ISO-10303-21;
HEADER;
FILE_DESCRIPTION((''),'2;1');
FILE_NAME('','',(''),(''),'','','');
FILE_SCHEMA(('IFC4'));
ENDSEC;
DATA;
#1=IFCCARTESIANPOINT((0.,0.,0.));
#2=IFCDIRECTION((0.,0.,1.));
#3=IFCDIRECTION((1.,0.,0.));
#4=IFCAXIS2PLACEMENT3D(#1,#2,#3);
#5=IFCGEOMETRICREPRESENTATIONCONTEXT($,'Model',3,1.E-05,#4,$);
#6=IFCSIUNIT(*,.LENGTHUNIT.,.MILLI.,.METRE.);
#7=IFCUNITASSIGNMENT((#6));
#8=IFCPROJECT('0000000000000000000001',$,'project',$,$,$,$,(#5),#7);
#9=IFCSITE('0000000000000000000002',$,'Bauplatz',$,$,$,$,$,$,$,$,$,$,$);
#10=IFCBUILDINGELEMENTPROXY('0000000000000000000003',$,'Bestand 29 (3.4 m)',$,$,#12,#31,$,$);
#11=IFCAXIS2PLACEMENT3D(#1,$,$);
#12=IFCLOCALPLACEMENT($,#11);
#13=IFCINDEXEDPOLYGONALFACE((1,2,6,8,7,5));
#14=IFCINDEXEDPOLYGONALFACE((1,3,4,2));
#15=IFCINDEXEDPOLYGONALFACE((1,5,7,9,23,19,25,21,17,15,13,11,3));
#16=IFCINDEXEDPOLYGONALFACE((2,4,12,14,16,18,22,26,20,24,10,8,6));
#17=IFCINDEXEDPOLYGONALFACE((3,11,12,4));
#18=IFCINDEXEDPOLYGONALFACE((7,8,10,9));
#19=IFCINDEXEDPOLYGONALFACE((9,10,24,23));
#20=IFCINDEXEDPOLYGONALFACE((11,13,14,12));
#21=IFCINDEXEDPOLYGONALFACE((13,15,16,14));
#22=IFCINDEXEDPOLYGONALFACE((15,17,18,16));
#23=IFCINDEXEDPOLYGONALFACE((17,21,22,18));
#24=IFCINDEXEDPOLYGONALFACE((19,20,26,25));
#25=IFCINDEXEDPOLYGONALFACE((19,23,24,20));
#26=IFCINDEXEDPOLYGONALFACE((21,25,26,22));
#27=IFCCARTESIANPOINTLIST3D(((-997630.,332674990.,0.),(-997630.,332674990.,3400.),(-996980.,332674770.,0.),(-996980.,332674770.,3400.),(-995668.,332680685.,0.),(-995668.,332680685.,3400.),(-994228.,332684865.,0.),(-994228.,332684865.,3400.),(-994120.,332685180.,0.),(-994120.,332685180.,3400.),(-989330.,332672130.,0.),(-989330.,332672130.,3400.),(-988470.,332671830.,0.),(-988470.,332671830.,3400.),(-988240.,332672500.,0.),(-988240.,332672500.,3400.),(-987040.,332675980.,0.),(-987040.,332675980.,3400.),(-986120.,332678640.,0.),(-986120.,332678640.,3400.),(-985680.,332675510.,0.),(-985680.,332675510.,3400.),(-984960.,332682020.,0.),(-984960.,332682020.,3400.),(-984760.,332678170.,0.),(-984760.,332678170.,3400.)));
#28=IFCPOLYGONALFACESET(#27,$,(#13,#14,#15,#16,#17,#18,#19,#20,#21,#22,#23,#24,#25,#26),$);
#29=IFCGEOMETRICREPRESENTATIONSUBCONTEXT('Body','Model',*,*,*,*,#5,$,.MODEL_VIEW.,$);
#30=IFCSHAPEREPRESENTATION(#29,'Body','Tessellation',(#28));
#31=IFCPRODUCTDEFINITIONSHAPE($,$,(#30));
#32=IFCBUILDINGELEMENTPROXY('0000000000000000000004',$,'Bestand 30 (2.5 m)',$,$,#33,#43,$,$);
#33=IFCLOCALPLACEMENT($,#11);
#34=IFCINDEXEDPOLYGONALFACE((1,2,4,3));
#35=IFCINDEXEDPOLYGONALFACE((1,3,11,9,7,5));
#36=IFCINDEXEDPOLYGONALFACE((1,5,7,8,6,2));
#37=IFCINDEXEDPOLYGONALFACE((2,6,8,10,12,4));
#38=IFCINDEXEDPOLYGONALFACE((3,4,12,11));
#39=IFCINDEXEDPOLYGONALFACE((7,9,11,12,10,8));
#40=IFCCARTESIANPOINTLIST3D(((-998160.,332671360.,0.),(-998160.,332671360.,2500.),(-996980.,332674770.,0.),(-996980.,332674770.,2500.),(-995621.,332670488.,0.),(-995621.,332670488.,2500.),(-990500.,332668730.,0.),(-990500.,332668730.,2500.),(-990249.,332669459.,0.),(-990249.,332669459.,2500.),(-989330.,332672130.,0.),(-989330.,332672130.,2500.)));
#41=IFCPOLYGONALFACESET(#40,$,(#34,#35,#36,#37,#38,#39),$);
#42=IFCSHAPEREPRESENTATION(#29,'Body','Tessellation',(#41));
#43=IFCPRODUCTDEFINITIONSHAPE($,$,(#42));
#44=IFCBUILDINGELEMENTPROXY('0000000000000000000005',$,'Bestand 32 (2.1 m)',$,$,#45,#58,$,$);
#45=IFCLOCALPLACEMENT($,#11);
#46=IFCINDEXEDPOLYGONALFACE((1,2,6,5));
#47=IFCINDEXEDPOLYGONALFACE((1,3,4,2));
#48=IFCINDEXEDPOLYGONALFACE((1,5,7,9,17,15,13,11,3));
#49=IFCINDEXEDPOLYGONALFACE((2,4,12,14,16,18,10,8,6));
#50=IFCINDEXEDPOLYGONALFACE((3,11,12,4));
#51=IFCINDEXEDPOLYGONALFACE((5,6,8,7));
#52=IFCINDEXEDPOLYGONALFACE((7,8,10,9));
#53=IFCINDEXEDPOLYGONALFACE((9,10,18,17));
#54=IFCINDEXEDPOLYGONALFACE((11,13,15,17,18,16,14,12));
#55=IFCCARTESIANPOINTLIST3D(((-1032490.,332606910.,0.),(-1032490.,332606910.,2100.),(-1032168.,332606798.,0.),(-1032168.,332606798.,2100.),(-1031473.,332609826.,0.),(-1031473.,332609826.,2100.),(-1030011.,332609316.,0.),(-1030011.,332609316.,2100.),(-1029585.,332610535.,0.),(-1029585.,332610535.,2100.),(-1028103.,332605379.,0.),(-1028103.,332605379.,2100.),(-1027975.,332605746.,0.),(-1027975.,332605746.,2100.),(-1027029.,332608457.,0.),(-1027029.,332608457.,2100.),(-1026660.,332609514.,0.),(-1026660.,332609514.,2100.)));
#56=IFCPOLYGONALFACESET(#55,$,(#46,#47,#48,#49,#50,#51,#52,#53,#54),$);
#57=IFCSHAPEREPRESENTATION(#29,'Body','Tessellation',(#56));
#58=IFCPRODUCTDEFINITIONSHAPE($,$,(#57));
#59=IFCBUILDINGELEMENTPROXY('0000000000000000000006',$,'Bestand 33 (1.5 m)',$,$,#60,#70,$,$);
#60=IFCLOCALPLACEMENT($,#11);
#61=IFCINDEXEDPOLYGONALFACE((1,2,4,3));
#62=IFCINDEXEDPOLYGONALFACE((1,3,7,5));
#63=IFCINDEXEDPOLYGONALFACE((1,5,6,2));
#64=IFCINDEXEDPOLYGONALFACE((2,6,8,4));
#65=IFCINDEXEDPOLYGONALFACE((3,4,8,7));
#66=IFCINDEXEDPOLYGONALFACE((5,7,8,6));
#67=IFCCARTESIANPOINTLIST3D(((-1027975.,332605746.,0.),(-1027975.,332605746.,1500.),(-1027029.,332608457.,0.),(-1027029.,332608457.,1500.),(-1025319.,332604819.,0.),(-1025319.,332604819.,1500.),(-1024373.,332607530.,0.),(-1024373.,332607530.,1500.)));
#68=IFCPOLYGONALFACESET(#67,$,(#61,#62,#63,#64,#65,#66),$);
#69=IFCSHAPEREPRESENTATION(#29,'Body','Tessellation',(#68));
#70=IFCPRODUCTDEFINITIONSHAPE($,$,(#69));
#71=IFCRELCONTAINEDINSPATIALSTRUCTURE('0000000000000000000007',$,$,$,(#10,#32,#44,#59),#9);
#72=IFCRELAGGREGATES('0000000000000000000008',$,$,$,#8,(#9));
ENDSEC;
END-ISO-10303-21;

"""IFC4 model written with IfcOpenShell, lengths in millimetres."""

from ifc_helpers import new_model, si_unit, origin_with_axes, place, context, subcontext, project, spatial, indexed_curve, outline, extrude, element, save


model = new_model("IFC4")

# Units and contexts
model_context = context("Model", 3, precision=1e-05, world=origin_with_axes())
body_context = subcontext(model_context, "Body", "Model", "MODEL_VIEW")
ifc_project = project(units=[si_unit("LENGTHUNIT", "METRE", prefix="MILLI")], contexts=[model_context])

# Site
site = spatial("IfcSite", under=ifc_project, Name="Bauplatz")

# Building element proxies
proxy_1_placement = place(None, origin_with_axes())
element("IfcBuildingElementProxy", 1, at=proxy_1_placement, inside=site, Name="Bestand 29 (3.4 m)", context=body_context, shape_type="SweptSolid", body=[
    extrude(outline(indexed_curve([(-984960.0, 332682020.0), (-994120.0, 332685180.0), (-994228.0, 332684865.0), (-995668.0, 332680685.0), (-997630.0, 332674990.0), (-996980.0, 332674770.0), (-989330.0, 332672130.0), (-988470.0, 332671830.0), (-988240.0, 332672500.0), (-987040.0, 332675980.0), (-985680.0, 332675510.0), (-984760.0, 332678170.0), (-986120.0, 332678640.0)])), None, (0.0, 0.0, 1.0), 3400.0),
])
proxy_2_placement = place(None, origin_with_axes())
element("IfcBuildingElementProxy", 2, at=proxy_2_placement, inside=site, Name="Bestand 30 (2.5 m)", context=body_context, shape_type="SweptSolid", body=[
    extrude(outline(indexed_curve([(-989330.0, 332672130.0), (-996980.0, 332674770.0), (-998160.0, 332671360.0), (-995621.0, 332670488.0), (-990500.0, 332668730.0), (-990249.0, 332669459.0)])), None, (0.0, 0.0, 1.0), 2500.0),
])
proxy_3_placement = place(None, origin_with_axes())
element("IfcBuildingElementProxy", 3, at=proxy_3_placement, inside=site, Name="Bestand 32 (2.1 m)", context=body_context, shape_type="SweptSolid", body=[
    extrude(outline(indexed_curve([(-1026660.0, 332609514.0), (-1029585.0, 332610535.0), (-1030011.0, 332609316.0), (-1031473.0, 332609826.0), (-1032490.0, 332606910.0), (-1032168.0, 332606798.0), (-1028103.0, 332605379.0), (-1027975.0, 332605746.0), (-1027029.0, 332608457.0)])), None, (0.0, 0.0, 1.0), 2100.0),
])
proxy_4_placement = place(None, origin_with_axes())
element("IfcBuildingElementProxy", 4, at=proxy_4_placement, inside=site, Name="Bestand 33 (1.5 m)", context=body_context, shape_type="SweptSolid", body=[
    extrude(outline(indexed_curve([(-1024373.0, 332607530.0), (-1027029.0, 332608457.0), (-1027975.0, 332605746.0), (-1025319.0, 332604819.0)])), None, (0.0, 0.0, 1.0), 1500.0),
])

save(model, "model.ifc")
